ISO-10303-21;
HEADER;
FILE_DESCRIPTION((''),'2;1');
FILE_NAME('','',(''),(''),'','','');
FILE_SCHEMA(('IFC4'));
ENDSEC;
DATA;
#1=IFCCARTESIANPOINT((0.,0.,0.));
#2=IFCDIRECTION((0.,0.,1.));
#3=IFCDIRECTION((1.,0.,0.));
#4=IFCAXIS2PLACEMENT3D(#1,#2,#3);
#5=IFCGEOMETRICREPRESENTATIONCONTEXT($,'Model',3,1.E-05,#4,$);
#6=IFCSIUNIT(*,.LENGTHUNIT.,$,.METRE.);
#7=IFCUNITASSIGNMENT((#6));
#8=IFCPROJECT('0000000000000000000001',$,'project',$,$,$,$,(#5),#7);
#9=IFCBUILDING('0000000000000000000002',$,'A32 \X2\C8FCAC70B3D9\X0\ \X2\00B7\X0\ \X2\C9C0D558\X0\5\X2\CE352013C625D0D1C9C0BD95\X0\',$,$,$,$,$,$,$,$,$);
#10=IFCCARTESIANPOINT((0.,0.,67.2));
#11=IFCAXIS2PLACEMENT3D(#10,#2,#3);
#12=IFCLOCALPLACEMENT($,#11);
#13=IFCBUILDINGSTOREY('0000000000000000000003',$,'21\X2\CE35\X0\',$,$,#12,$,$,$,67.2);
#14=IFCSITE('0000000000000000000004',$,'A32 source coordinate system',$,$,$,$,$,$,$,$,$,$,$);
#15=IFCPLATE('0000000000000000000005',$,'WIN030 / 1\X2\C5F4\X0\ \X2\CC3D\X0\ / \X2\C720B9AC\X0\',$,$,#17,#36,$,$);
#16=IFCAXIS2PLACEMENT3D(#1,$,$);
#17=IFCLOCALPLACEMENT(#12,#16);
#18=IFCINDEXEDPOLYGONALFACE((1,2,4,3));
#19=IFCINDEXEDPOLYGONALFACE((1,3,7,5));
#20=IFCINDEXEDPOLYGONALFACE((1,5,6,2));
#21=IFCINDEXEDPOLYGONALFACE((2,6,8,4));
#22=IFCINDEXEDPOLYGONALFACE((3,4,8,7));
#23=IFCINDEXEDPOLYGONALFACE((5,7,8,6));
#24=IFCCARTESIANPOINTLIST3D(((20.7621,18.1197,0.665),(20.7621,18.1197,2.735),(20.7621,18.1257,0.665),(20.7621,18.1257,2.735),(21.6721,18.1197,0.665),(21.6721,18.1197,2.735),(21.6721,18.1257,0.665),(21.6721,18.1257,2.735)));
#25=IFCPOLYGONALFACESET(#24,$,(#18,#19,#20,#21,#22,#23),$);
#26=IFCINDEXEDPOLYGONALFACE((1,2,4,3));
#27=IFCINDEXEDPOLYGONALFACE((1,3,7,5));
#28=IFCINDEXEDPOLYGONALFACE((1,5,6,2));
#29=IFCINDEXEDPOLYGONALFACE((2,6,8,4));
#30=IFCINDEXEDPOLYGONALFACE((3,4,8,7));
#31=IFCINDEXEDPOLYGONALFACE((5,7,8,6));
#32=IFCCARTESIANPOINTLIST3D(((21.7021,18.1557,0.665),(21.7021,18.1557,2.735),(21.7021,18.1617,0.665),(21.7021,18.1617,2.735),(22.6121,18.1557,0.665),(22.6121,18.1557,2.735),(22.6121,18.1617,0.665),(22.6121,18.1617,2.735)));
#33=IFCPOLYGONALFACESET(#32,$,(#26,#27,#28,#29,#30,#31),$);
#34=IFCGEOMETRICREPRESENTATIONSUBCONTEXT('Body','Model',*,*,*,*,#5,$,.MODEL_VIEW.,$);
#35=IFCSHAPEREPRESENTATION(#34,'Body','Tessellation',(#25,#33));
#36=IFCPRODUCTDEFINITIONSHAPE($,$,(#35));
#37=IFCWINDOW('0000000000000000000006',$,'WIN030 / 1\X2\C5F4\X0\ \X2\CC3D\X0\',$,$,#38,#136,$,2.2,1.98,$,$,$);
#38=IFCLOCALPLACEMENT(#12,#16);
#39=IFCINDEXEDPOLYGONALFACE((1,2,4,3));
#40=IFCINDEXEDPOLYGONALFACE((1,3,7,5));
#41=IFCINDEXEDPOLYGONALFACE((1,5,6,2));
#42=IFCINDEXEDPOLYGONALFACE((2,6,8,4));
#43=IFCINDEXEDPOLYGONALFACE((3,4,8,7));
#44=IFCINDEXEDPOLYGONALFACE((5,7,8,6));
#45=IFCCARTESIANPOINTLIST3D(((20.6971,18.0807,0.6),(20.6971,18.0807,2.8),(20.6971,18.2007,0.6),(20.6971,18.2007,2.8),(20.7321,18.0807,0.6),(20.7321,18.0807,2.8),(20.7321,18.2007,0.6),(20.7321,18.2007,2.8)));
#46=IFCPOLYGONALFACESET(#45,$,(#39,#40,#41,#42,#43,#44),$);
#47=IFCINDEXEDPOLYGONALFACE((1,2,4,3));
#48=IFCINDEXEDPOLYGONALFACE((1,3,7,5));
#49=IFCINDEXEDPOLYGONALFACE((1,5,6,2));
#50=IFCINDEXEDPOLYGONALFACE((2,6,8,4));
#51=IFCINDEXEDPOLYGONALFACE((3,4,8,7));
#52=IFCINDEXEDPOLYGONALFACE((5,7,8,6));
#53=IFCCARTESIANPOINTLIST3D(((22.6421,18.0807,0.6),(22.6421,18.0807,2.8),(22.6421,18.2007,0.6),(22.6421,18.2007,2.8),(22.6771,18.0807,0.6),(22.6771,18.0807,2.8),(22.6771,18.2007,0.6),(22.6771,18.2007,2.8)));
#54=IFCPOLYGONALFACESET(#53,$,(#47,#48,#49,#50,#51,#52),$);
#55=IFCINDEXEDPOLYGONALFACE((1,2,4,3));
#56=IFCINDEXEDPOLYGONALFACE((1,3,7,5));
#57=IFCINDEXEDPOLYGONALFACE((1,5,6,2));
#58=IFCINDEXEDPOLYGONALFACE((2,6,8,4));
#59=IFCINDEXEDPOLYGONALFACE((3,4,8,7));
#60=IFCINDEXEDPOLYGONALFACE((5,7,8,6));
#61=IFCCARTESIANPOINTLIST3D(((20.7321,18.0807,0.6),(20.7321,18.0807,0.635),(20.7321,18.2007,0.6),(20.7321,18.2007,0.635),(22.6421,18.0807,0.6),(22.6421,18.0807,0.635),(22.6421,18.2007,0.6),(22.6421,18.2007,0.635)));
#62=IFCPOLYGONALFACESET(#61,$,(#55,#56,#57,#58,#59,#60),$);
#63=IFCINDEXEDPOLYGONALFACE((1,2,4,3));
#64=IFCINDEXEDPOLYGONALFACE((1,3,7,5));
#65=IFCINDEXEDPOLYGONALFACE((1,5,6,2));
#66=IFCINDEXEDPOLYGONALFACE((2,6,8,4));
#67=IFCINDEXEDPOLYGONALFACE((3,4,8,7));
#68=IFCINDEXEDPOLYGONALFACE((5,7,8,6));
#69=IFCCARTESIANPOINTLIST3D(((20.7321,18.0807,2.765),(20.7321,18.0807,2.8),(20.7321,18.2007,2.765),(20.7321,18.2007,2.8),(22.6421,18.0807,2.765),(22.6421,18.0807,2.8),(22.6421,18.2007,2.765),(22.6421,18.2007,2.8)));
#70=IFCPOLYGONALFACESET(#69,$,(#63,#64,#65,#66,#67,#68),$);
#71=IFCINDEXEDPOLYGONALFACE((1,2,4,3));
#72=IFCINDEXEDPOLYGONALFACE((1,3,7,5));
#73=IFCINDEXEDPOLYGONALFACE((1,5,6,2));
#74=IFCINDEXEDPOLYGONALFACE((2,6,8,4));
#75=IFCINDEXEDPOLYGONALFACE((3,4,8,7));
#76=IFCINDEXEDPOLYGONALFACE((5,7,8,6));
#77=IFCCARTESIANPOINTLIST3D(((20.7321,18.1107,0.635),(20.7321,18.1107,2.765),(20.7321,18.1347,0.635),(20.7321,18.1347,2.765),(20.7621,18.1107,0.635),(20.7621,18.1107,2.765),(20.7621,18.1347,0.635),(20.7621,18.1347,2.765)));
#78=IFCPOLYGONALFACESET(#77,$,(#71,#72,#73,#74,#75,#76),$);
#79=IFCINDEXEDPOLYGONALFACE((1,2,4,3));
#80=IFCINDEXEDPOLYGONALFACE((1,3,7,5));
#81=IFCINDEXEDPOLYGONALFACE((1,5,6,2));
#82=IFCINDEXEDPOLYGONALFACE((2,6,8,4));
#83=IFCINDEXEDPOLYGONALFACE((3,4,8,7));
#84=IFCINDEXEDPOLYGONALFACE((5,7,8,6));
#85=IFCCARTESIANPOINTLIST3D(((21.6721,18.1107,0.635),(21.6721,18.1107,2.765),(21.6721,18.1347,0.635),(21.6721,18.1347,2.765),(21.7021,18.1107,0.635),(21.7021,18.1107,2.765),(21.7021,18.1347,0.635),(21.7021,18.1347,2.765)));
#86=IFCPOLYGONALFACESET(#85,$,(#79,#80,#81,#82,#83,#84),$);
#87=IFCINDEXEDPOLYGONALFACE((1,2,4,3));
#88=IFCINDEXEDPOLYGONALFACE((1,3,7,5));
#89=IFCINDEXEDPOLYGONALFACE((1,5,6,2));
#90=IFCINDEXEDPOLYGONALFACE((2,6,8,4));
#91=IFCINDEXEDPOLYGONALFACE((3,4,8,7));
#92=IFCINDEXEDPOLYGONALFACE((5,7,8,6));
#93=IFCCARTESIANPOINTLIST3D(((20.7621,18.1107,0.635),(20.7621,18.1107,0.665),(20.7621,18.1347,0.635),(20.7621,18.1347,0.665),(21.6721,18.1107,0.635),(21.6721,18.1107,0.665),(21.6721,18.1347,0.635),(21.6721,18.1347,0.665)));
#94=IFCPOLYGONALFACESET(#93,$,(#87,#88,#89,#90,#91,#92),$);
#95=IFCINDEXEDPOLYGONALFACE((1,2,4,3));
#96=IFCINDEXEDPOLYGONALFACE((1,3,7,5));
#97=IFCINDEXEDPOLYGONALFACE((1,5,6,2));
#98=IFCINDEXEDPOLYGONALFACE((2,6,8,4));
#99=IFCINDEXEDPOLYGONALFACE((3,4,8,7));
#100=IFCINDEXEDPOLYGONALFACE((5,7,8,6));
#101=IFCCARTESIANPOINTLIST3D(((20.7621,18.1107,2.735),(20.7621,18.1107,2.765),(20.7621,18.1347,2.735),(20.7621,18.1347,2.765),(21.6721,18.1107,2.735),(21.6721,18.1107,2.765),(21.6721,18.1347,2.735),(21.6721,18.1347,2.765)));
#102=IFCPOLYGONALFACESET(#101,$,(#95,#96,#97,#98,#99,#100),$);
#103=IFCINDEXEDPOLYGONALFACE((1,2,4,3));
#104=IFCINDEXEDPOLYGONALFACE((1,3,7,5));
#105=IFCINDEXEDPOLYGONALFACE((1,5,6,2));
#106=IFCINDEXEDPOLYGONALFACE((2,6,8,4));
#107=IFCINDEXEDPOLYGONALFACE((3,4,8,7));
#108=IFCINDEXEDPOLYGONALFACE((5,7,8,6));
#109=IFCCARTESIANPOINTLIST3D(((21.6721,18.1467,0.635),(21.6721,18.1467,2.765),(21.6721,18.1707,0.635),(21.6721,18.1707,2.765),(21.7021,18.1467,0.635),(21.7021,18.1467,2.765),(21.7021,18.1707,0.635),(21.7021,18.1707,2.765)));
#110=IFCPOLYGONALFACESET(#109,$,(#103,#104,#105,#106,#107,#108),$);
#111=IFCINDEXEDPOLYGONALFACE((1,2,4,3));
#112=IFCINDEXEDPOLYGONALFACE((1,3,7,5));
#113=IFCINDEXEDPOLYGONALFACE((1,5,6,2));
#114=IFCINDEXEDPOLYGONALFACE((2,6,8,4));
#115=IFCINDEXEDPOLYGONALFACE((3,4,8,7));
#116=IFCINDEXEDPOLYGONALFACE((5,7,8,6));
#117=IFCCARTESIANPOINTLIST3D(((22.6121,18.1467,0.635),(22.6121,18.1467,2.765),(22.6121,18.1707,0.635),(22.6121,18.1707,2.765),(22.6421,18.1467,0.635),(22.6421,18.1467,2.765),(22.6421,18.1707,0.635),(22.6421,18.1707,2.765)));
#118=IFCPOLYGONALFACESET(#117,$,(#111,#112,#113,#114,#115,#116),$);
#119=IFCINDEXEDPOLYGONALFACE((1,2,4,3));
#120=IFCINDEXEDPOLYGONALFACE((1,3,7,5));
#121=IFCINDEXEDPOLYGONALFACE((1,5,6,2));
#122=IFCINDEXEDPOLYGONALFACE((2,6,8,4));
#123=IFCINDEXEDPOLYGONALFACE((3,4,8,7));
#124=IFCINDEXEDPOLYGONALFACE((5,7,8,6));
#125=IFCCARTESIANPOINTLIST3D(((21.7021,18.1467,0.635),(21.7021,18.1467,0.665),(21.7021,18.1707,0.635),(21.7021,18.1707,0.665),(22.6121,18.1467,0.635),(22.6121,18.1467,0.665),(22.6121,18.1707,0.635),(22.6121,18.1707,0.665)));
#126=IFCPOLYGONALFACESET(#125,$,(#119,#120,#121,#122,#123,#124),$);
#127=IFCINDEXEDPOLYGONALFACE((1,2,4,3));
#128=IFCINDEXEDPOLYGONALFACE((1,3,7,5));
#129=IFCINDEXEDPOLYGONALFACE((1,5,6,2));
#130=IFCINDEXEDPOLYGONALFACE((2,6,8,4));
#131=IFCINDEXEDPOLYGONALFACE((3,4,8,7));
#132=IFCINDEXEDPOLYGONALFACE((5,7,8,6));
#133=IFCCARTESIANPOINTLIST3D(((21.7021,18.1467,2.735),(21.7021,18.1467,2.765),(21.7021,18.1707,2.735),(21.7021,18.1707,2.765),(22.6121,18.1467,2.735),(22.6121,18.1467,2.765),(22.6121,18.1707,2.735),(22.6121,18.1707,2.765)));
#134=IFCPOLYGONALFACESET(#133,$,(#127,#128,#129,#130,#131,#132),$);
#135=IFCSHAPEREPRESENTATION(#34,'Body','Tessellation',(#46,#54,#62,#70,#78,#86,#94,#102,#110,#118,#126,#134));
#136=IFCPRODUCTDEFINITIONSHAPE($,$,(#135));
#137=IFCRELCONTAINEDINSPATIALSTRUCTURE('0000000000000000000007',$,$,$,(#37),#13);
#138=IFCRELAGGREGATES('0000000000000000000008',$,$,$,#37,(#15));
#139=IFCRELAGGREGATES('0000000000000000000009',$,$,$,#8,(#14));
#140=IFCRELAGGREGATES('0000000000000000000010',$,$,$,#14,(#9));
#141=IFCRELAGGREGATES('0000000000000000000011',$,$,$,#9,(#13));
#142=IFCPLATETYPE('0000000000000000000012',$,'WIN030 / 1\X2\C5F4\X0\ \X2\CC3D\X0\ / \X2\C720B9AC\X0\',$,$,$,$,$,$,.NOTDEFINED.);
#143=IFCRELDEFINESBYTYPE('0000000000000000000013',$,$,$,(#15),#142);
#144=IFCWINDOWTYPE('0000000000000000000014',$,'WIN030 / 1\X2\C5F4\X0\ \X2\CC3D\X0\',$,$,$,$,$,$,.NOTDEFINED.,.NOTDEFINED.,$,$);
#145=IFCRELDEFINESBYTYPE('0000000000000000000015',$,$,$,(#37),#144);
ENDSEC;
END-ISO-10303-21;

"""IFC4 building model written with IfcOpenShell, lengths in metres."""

from ifc_helpers import new_model, si_unit, frame, origin, origin_with_axes, place, context, subcontext, project, spatial, polyline, outline, extrude, source, transform, mapped, type_object, type_shapes, element, aggregate, save


model = new_model("IFC4")

# Units and contexts
model_context = context("Model", 3, precision=1e-05, world=origin_with_axes())
body_context = subcontext(model_context, "Body", "Model", "MODEL_VIEW")
ifc_project = project(units=[si_unit("LENGTHUNIT", "METRE")], contexts=[model_context])

# Plate
storey_placement = place(None, frame((0.0, 0.0, 67.2), z_axis=(0.0, 0.0, 1.0), x_axis=(1.0, 0.0, 0.0)))
plate_type_1 = type_object("IfcPlateType", Name="WIN030 / 1열 창 / 유리", PredefinedType="NOTDEFINED")
shared_shape_1 = source(origin(), body_context, "Body", "SweptSolid", [
    extrude(outline(polyline([(20.7621, 18.1197), (20.7621, 18.1257), (21.6721, 18.1257), (21.6721, 18.1197), (20.7621, 18.1197)])), frame((0.0, 0.0, 0.665)), (0.0, 0.0, 1.0), 2.07),
    extrude(outline(polyline([(21.7021, 18.1557), (21.7021, 18.1617), (22.6121, 18.1617), (22.6121, 18.1557), (21.7021, 18.1557)])), frame((0.0, 0.0, 0.665)), (0.0, 0.0, 1.0), 2.07),
])
type_shapes(plate_type_1, [shared_shape_1])
window_1_placement = place(storey_placement, origin_with_axes())
plate_1_placement = place(window_1_placement, origin_with_axes())
plate_1 = element("IfcPlate", 1, at=plate_1_placement, type_object=plate_type_1, Name="WIN030 / 1열 창 / 유리", context=body_context, shape_type="MappedRepresentation", body=[
    mapped(shared_shape_1, transform((0.0, 0.0, 0.0), scale=1.0)),
])

# Site, building, storey
site = spatial("IfcSite", under=ifc_project, Name="A32 source coordinate system")
building = spatial("IfcBuilding", under=site, Name="A32 주거동 · 지하5층–옥탑지붕")
storey = spatial("IfcBuildingStorey", under=building, at=storey_placement, Name="21층", Elevation=67.2)

# Window
window_type_1 = type_object("IfcWindowType", Name="WIN030 / 1열 창", PartitioningType="NOTDEFINED", PredefinedType="NOTDEFINED")
shared_shape_2 = source(origin(), body_context, "Body", "SweptSolid", [
    extrude(outline(polyline([(20.6971, 18.0807), (20.6971, 18.2007), (20.7321, 18.2007), (20.7321, 18.0807), (20.6971, 18.0807)])), frame((0.0, 0.0, 0.6)), (0.0, 0.0, 1.0), 2.2),
    extrude(outline(polyline([(22.6421, 18.0807), (22.6421, 18.2007), (22.6771, 18.2007), (22.6771, 18.0807), (22.6421, 18.0807)])), frame((0.0, 0.0, 0.6)), (0.0, 0.0, 1.0), 2.2),
    extrude(outline(polyline([(20.7321, 18.0807), (20.7321, 18.2007), (22.6421, 18.2007), (22.6421, 18.0807), (20.7321, 18.0807)])), frame((0.0, 0.0, 0.6)), (0.0, 0.0, 1.0), 0.035),
    extrude(outline(polyline([(20.7321, 18.0807), (20.7321, 18.2007), (22.6421, 18.2007), (22.6421, 18.0807), (20.7321, 18.0807)])), frame((0.0, 0.0, 2.765)), (0.0, 0.0, 1.0), 0.035),
    extrude(outline(polyline([(20.7321, 18.1107), (20.7321, 18.1347), (20.7621, 18.1347), (20.7621, 18.1107), (20.7321, 18.1107)])), frame((0.0, 0.0, 0.635)), (0.0, 0.0, 1.0), 2.13),
    extrude(outline(polyline([(21.6721, 18.1107), (21.6721, 18.1347), (21.7021, 18.1347), (21.7021, 18.1107), (21.6721, 18.1107)])), frame((0.0, 0.0, 0.635)), (0.0, 0.0, 1.0), 2.13),
    extrude(outline(polyline([(20.7621, 18.1107), (20.7621, 18.1347), (21.6721, 18.1347), (21.6721, 18.1107), (20.7621, 18.1107)])), frame((0.0, 0.0, 0.635)), (0.0, 0.0, 1.0), 0.03),
    extrude(outline(polyline([(20.7621, 18.1107), (20.7621, 18.1347), (21.6721, 18.1347), (21.6721, 18.1107), (20.7621, 18.1107)])), frame((0.0, 0.0, 2.735)), (0.0, 0.0, 1.0), 0.03),
    extrude(outline(polyline([(21.6721, 18.1467), (21.6721, 18.1707), (21.7021, 18.1707), (21.7021, 18.1467), (21.6721, 18.1467)])), frame((0.0, 0.0, 0.635)), (0.0, 0.0, 1.0), 2.13),
    extrude(outline(polyline([(22.6121, 18.1467), (22.6121, 18.1707), (22.6421, 18.1707), (22.6421, 18.1467), (22.6121, 18.1467)])), frame((0.0, 0.0, 0.635)), (0.0, 0.0, 1.0), 2.13),
    extrude(outline(polyline([(21.7021, 18.1467), (21.7021, 18.1707), (22.6121, 18.1707), (22.6121, 18.1467), (21.7021, 18.1467)])), frame((0.0, 0.0, 0.635)), (0.0, 0.0, 1.0), 0.03),
    extrude(outline(polyline([(21.7021, 18.1467), (21.7021, 18.1707), (22.6121, 18.1707), (22.6121, 18.1467), (21.7021, 18.1467)])), frame((0.0, 0.0, 2.735)), (0.0, 0.0, 1.0), 0.03),
])
type_shapes(window_type_1, [shared_shape_2])
window_1 = element("IfcWindow", 2, at=window_1_placement, inside=storey, type_object=window_type_1, Name="WIN030 / 1열 창", OverallHeight=2.2, OverallWidth=1.98, context=body_context, shape_type="MappedRepresentation", body=[
    mapped(shared_shape_2, transform((0.0, 0.0, 0.0), scale=1.0)),
])
aggregate(window_1, [plate_1])

save(model, "model.ifc")
